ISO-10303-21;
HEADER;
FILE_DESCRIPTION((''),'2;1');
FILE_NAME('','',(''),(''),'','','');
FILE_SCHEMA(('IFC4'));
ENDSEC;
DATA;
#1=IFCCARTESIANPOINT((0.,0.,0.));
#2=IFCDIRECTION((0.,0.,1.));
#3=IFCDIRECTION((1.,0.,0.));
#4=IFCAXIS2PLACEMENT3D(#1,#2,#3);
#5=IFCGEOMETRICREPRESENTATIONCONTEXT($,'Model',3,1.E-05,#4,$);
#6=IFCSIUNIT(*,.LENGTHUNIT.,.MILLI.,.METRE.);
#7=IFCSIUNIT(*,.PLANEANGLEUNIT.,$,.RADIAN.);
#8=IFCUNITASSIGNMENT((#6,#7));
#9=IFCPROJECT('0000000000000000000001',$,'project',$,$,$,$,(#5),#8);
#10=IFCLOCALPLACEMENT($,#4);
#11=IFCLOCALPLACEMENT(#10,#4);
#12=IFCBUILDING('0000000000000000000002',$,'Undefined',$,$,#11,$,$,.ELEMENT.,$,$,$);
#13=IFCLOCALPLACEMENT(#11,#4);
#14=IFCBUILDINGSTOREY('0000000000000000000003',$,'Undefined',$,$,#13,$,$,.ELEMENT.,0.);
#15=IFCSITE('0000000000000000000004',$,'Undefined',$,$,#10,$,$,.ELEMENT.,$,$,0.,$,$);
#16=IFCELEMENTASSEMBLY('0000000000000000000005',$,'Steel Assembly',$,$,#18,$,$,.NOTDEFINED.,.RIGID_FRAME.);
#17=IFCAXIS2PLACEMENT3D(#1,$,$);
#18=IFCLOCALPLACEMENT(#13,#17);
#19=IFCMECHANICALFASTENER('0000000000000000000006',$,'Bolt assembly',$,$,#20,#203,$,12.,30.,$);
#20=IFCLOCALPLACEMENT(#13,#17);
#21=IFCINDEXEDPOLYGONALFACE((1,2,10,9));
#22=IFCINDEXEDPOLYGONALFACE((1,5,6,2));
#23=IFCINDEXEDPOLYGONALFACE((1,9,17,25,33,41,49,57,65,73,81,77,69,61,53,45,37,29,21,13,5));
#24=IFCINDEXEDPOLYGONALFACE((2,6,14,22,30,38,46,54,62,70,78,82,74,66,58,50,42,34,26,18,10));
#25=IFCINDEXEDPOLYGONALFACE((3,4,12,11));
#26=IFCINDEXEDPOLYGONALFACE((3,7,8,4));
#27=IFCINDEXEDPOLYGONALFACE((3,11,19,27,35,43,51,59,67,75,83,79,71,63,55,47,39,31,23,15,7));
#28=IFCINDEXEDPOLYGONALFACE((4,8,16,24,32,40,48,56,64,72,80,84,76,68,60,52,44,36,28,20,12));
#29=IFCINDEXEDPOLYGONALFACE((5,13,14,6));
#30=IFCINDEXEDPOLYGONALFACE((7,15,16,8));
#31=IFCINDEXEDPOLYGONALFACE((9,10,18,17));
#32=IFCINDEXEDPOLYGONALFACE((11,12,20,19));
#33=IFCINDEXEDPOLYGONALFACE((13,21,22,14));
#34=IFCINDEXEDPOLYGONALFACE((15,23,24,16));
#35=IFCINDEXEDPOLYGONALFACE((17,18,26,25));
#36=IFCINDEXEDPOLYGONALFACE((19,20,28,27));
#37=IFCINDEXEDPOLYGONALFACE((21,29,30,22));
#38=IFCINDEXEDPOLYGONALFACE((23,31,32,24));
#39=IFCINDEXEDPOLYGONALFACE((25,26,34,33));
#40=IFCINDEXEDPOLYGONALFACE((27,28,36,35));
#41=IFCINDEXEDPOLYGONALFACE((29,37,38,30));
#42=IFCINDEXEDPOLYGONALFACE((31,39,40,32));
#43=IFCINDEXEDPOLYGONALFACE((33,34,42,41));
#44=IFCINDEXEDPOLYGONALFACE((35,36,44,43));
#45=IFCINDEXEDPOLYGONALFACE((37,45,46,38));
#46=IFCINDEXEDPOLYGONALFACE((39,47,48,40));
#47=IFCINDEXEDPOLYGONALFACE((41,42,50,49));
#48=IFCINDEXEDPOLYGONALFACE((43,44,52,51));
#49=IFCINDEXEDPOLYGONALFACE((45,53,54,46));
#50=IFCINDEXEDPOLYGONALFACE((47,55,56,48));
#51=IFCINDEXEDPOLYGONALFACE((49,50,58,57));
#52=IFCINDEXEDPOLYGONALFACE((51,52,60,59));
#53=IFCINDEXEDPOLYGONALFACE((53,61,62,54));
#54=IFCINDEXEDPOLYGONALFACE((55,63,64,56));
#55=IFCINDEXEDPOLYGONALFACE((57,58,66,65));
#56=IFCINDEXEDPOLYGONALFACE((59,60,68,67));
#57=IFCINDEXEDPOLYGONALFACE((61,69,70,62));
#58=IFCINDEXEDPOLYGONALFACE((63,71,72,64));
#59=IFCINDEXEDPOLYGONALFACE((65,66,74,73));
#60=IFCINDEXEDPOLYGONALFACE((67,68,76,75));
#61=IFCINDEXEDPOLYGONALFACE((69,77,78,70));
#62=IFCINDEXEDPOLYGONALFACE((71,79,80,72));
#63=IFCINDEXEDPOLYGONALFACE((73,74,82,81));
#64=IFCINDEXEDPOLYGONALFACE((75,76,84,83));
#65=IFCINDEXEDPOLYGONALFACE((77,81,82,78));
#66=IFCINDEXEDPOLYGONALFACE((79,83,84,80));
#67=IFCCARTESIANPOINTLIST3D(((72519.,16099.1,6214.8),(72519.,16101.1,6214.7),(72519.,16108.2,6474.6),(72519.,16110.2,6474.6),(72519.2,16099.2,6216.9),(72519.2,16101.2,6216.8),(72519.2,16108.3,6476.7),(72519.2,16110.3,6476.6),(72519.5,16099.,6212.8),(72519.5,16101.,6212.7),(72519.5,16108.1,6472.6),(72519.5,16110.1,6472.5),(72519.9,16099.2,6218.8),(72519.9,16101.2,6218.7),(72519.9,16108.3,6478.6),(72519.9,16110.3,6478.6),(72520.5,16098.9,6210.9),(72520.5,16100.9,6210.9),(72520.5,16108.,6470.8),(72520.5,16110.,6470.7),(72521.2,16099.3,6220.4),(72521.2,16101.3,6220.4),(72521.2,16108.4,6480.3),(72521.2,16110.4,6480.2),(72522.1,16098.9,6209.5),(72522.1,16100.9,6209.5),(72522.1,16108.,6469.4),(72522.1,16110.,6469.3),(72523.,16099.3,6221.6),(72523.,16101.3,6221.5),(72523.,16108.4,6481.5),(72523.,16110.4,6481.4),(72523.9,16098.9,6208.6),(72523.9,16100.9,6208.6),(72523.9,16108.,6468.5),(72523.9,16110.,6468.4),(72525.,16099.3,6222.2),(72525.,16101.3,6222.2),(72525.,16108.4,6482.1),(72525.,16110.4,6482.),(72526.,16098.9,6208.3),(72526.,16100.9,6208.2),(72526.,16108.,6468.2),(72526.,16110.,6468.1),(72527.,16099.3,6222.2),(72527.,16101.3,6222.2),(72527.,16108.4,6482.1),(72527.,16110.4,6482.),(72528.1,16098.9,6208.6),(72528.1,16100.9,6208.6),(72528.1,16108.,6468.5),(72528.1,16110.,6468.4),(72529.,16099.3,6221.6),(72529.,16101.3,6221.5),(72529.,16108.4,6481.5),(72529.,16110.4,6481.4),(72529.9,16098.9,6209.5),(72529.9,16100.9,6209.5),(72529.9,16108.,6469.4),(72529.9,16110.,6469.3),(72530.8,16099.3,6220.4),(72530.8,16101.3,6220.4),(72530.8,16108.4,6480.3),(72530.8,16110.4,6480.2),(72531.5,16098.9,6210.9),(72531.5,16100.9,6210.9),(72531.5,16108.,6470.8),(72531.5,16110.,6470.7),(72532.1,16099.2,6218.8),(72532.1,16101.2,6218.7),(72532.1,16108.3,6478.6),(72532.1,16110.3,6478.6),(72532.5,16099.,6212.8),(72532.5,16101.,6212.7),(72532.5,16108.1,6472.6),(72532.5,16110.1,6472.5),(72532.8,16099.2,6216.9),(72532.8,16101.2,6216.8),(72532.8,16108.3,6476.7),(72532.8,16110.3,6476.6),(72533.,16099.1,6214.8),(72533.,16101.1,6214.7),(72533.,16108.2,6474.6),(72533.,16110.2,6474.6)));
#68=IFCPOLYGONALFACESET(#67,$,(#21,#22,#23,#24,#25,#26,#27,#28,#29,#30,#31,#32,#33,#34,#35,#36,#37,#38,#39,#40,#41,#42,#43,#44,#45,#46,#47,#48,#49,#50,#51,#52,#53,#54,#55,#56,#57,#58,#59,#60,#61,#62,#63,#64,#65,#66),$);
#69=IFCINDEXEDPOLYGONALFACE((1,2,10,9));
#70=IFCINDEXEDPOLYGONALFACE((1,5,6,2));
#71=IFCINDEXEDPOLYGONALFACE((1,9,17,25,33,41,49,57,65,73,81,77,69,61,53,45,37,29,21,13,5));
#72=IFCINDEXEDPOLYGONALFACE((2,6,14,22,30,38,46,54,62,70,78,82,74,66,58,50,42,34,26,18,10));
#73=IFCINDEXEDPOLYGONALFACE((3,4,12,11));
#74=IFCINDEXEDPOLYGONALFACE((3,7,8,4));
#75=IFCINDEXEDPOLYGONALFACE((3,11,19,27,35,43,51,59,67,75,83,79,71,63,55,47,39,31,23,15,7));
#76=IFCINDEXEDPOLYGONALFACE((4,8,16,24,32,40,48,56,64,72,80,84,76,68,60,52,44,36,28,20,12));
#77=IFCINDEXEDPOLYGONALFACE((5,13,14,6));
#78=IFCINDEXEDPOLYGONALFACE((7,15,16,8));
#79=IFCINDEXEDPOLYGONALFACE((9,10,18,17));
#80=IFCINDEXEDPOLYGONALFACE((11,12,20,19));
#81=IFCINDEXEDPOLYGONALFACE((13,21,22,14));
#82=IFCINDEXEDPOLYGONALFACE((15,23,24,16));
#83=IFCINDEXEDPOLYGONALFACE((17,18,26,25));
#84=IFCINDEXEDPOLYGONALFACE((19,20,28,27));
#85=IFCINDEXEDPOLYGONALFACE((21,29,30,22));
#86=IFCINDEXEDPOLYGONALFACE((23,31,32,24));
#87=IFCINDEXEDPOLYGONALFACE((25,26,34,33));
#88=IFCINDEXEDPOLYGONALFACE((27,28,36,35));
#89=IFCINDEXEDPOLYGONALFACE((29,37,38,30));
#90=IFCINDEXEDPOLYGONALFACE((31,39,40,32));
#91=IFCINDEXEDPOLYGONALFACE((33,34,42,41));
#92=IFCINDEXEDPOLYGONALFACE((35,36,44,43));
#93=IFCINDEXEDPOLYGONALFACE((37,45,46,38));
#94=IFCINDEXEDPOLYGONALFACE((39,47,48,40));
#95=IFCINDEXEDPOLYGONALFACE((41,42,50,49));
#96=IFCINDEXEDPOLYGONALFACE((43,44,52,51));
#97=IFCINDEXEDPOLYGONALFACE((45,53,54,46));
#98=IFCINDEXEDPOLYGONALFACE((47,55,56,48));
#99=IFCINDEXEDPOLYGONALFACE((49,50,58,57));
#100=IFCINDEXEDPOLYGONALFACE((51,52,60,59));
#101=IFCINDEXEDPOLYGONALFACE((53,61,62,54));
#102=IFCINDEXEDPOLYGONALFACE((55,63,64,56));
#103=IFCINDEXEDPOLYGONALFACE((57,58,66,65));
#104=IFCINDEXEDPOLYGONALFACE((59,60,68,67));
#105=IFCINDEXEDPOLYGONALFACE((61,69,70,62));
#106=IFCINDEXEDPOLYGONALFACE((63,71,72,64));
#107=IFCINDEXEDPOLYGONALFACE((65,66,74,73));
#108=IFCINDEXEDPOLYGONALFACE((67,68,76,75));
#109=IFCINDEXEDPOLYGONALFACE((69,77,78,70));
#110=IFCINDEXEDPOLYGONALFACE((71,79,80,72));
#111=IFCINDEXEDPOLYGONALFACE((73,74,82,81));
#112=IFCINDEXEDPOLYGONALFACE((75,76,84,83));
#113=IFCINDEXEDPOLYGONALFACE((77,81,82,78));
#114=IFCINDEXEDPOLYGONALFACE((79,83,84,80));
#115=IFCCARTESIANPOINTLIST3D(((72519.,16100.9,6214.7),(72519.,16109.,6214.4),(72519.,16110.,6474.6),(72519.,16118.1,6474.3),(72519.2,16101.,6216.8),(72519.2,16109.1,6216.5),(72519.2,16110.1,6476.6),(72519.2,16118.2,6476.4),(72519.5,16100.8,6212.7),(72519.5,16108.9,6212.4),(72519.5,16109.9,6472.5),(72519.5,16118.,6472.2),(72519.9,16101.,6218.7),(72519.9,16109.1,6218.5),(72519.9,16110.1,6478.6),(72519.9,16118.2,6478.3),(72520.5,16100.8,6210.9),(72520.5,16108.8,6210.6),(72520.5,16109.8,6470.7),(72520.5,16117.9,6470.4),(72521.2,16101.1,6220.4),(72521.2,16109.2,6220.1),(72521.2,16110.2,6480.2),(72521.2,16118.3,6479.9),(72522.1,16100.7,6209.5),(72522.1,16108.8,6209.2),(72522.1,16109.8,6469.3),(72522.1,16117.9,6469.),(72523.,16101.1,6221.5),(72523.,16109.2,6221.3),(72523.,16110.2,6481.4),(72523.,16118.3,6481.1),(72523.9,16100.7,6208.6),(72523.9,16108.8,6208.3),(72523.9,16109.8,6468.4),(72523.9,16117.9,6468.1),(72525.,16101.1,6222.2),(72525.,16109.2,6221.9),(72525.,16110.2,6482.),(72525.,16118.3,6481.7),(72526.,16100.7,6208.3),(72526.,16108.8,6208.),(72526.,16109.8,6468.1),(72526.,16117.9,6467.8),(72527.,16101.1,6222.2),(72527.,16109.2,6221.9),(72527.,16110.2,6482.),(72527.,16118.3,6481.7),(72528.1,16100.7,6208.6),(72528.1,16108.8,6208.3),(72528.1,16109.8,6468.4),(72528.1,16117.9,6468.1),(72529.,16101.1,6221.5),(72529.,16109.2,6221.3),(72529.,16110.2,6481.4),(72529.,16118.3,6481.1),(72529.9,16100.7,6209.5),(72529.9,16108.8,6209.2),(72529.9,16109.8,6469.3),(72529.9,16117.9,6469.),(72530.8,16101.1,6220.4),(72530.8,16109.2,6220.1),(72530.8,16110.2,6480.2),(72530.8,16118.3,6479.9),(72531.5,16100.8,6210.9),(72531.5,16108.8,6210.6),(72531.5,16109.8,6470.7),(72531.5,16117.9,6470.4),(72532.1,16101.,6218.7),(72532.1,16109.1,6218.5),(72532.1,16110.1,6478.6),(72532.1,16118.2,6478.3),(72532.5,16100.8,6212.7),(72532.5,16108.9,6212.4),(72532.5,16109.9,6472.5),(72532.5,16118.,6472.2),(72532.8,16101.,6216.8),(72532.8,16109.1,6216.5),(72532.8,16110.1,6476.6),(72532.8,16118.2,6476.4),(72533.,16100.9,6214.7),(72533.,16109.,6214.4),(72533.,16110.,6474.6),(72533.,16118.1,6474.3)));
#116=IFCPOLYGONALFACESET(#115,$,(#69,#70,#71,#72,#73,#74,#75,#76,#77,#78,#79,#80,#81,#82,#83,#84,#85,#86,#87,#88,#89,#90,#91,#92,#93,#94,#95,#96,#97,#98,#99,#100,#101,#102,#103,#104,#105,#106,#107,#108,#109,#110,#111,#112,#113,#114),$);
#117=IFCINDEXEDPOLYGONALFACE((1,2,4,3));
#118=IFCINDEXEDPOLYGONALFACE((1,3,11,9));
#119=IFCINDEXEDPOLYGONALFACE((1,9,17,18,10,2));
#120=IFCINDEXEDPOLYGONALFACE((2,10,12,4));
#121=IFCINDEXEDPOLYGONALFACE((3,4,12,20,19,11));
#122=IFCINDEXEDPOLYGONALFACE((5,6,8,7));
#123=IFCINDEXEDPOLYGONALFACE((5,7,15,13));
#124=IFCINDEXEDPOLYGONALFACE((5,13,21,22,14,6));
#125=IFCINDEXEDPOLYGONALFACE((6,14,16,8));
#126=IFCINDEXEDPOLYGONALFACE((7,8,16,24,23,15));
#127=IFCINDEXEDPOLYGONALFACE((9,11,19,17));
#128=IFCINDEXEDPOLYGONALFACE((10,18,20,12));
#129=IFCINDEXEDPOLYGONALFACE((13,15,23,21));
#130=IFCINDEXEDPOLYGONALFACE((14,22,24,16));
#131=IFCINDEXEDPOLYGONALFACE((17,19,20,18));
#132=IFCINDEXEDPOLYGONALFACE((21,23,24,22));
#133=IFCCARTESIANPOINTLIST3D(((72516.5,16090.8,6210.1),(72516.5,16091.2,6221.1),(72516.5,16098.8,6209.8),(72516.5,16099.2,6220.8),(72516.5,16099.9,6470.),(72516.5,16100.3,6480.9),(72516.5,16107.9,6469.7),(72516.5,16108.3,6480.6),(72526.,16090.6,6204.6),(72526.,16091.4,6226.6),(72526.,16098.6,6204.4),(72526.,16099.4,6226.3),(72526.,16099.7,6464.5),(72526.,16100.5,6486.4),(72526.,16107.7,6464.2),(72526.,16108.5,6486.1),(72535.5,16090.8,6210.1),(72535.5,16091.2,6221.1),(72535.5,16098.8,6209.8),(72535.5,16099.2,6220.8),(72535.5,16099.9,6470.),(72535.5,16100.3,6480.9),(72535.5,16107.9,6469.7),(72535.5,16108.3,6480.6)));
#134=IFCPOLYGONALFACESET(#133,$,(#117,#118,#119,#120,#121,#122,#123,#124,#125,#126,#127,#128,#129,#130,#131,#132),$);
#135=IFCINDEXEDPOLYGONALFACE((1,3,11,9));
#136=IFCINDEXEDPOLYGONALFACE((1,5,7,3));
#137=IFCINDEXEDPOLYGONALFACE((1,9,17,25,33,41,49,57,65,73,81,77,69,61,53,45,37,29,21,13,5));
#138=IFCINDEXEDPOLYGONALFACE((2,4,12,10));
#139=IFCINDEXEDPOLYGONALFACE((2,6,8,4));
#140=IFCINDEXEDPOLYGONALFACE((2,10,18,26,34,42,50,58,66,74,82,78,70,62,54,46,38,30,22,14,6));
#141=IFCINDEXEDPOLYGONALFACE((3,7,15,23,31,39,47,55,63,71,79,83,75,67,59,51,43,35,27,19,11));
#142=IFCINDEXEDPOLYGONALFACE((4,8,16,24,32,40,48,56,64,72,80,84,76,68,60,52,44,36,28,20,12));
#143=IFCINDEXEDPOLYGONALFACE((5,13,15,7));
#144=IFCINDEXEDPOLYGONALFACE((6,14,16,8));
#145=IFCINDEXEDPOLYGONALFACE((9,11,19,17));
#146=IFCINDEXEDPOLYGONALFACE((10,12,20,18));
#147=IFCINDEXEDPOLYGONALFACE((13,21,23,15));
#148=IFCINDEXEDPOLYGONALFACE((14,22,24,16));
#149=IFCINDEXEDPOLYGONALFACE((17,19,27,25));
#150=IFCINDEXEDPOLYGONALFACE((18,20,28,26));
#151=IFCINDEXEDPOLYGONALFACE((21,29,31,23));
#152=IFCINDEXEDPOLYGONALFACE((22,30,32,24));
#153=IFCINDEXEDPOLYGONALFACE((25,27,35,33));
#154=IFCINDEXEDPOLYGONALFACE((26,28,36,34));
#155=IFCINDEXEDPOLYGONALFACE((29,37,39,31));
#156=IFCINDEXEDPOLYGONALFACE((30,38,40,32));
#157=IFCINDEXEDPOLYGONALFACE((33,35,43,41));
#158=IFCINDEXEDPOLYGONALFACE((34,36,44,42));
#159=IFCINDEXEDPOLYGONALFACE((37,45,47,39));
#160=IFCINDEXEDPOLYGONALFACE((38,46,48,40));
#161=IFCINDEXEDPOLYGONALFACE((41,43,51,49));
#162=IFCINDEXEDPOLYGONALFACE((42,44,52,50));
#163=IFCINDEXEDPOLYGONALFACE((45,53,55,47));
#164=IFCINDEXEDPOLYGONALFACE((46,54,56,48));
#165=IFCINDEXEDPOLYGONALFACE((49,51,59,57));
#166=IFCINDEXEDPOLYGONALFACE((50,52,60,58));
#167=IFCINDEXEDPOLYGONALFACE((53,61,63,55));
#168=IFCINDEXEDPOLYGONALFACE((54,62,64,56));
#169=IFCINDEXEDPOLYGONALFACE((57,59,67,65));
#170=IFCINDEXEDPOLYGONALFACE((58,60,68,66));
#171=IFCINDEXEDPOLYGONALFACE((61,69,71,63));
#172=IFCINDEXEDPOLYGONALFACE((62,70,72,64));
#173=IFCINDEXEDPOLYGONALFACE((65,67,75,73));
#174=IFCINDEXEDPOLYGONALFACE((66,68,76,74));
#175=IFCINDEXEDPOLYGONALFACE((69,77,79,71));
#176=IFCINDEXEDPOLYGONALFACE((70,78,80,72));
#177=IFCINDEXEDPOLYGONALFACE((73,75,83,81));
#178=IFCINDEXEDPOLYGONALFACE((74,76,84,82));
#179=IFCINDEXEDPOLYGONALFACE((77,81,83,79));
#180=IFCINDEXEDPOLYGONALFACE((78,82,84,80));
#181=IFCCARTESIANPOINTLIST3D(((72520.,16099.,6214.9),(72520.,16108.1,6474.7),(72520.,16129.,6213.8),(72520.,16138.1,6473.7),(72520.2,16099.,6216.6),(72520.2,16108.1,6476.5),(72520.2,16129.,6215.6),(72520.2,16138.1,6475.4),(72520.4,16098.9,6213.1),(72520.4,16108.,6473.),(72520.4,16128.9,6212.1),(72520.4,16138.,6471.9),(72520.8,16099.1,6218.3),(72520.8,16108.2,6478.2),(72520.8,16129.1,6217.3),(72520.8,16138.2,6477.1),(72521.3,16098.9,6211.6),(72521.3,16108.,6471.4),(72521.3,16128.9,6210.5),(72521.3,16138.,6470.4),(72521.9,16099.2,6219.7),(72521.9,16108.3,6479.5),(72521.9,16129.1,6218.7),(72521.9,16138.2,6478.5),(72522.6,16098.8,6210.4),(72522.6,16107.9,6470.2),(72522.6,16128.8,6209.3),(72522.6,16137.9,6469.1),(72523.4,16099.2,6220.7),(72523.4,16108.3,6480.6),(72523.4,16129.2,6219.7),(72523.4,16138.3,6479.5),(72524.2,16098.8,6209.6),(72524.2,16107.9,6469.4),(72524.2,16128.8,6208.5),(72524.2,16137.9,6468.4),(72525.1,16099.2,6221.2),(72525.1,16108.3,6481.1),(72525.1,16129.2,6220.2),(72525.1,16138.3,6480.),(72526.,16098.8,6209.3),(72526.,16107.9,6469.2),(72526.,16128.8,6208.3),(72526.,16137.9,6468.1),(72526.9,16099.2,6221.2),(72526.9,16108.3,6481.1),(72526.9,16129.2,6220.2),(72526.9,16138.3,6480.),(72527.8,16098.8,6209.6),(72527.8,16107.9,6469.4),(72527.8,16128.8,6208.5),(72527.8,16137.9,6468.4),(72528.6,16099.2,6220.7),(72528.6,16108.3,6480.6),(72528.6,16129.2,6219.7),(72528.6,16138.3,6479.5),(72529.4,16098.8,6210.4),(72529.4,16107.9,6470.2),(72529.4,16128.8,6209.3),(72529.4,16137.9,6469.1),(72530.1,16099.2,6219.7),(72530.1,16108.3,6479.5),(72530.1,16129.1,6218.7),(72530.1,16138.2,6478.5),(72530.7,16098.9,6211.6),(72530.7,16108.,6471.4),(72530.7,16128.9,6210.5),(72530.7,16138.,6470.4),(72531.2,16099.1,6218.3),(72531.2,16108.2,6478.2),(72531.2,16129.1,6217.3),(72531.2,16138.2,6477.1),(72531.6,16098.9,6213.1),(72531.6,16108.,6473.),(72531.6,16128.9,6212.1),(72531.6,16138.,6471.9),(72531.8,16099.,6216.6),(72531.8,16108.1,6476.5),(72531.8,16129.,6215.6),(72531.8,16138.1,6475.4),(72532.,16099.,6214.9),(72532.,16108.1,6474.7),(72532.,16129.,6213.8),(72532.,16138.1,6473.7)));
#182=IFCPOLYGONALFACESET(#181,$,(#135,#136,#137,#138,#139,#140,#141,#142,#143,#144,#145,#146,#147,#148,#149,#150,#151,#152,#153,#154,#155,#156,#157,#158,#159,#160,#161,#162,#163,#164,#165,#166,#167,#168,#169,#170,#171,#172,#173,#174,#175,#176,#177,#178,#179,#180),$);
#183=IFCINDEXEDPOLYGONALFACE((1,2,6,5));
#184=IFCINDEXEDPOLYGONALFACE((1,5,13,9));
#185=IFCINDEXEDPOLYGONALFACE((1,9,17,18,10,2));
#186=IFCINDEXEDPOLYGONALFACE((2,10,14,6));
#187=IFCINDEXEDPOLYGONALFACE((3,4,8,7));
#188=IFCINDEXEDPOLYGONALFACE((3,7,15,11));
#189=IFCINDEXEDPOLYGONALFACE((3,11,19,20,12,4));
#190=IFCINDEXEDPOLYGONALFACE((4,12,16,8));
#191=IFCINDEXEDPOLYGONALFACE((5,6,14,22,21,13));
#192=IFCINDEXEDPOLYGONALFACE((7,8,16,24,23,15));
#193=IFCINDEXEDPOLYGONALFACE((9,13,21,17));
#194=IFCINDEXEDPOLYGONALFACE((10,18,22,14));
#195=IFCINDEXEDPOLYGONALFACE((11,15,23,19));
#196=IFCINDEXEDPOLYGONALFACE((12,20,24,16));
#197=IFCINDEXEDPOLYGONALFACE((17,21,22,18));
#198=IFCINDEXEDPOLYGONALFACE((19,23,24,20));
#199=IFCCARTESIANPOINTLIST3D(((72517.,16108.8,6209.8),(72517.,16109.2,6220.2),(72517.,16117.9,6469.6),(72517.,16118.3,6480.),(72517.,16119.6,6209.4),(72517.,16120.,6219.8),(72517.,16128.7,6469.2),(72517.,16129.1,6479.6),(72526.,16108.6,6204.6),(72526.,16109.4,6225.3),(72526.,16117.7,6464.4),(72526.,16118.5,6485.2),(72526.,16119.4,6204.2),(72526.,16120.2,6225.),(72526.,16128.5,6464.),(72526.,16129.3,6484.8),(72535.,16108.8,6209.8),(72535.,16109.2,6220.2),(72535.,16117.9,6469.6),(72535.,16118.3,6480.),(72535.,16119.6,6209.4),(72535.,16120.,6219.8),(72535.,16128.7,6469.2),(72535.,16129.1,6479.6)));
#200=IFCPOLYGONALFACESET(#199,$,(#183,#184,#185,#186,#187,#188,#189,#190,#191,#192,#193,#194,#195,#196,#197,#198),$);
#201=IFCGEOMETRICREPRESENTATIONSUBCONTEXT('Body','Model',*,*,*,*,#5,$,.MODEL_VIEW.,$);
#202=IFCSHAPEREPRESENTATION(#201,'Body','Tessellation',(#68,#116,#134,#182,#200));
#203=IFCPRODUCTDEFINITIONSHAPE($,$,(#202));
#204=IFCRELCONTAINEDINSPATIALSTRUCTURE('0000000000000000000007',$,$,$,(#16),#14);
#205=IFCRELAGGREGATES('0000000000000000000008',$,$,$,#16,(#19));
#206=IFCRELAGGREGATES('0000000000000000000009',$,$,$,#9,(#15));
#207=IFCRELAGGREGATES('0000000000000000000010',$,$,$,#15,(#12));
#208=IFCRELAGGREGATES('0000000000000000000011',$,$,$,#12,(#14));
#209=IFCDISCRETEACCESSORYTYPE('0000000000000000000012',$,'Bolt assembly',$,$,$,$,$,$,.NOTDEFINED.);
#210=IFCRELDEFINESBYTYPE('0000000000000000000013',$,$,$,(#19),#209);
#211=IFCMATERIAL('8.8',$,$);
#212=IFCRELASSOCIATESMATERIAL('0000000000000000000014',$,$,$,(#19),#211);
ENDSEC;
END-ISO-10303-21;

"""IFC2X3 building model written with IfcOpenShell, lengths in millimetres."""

from ifc_helpers import new_model, si_unit, frame, origin_with_axes, origin_2d_with_axis, place, context, subcontext, project, spatial, polyline, circle, outline, extrude, source, transform, mapped, material, type_object, element, aggregate, save


model = new_model("IFC2X3")

# Units and contexts
model_context = context("Model", 3, precision=1e-05, world=origin_with_axes())
body_context = subcontext(model_context, "Body", "Model", "MODEL_VIEW")
ifc_project = project(units=[si_unit("LENGTHUNIT", "METRE", prefix="MILLI"), si_unit("PLANEANGLEUNIT", "RADIAN")], contexts=[model_context])

# Site, building, storey
site_placement = place(None, origin_with_axes())
site = spatial("IfcSite", under=ifc_project, at=site_placement, Name="Undefined", CompositionType="ELEMENT", RefElevation=0.0)
building_placement = place(site_placement, origin_with_axes())
building = spatial("IfcBuilding", under=site, at=building_placement, Name="Undefined", CompositionType="ELEMENT")
storey_placement = place(building_placement, origin_with_axes())
storey = spatial("IfcBuildingStorey", under=building, at=storey_placement, Name="Undefined", CompositionType="ELEMENT", Elevation=0.0)

# Element assembly
assembly_1_placement = place(storey_placement, origin_with_axes())
assembly_1 = element("IfcElementAssembly", 1, at=assembly_1_placement, inside=storey, Name="Steel Assembly", AssemblyPlace="NOTDEFINED", PredefinedType="RIGID_FRAME")

# Shared definitions
discrete_accessory_type_1 = type_object("IfcDiscreteAccessoryType", Name="Bolt assembly")
ifc_material_1 = material(Name="8.8")

# Mechanical fastener
shared_shape_1 = source(origin_with_axes(), body_context, "Body", "SweptSolid", [
    extrude(circle(Radius=7.0, at=origin_2d_with_axis()), frame((0.0, -1.9, 0.0), z_axis=(0.0, 1.0, 0.0), x_axis=(1.0, 0.0, 0.0)), (0.0, 0.0, 1.0), 2.0),
    extrude(circle(Radius=7.0, at=origin_2d_with_axis()), frame((0.0, -0.1, 0.0), z_axis=(0.0, 1.0, 0.0), x_axis=(1.0, 0.0, 0.0)), (0.0, 0.0, 1.0), 8.1),
    extrude(outline(polyline([(11.0, 0.0), (5.5, 9.5), (-5.5, 9.5), (-11.0, 0.0), (-5.5, -9.5), (5.5, -9.5), (11.0, 0.0)])), frame((0.0, -10.0, 0.0), z_axis=(0.0, 1.0, 0.0), x_axis=(1.0, 0.0, 0.0)), (0.0, 0.0, 1.0), 8.0),
    extrude(circle(Radius=6.0, at=origin_2d_with_axis()), frame((0.0, -2.0, 0.0), z_axis=(0.0, 1.0, 0.0), x_axis=(1.0, 0.0, 0.0)), (0.0, 0.0, 1.0), 30.0),
    extrude(outline(polyline([(10.4, 0.0), (5.2, 9.0), (-5.2, 9.0), (-10.4, 0.0), (-5.2, -9.0), (5.2, -9.0), (10.4, 0.0)])), frame((0.0, 8.0, 0.0), z_axis=(0.0, 1.0, 0.0), x_axis=(1.0, 0.0, 0.0)), (0.0, 0.0, 1.0), 10.8),
])
mechanical_fastener_1_placement = place(assembly_1_placement, frame((72526.0, 16110.1, 6475.1), z_axis=(1.0, 0.0, 0.0), x_axis=(0.0, -0.034997, -0.999387)))
mechanical_fastener_1 = element("IfcMechanicalFastener", 2, at=mechanical_fastener_1_placement, type_object=discrete_accessory_type_1, material=ifc_material_1, Name="Bolt assembly", NominalDiameter=12.0, NominalLength=30.0, context=body_context, shape_type="MappedRepresentation", body=[
    mapped(shared_shape_1, transform((0.0, 0.0, 0.0))),
    mapped(shared_shape_1, transform((260.0, 0.0, 0.0))),
])
aggregate(assembly_1, [mechanical_fastener_1])

save(model, "model.ifc")
